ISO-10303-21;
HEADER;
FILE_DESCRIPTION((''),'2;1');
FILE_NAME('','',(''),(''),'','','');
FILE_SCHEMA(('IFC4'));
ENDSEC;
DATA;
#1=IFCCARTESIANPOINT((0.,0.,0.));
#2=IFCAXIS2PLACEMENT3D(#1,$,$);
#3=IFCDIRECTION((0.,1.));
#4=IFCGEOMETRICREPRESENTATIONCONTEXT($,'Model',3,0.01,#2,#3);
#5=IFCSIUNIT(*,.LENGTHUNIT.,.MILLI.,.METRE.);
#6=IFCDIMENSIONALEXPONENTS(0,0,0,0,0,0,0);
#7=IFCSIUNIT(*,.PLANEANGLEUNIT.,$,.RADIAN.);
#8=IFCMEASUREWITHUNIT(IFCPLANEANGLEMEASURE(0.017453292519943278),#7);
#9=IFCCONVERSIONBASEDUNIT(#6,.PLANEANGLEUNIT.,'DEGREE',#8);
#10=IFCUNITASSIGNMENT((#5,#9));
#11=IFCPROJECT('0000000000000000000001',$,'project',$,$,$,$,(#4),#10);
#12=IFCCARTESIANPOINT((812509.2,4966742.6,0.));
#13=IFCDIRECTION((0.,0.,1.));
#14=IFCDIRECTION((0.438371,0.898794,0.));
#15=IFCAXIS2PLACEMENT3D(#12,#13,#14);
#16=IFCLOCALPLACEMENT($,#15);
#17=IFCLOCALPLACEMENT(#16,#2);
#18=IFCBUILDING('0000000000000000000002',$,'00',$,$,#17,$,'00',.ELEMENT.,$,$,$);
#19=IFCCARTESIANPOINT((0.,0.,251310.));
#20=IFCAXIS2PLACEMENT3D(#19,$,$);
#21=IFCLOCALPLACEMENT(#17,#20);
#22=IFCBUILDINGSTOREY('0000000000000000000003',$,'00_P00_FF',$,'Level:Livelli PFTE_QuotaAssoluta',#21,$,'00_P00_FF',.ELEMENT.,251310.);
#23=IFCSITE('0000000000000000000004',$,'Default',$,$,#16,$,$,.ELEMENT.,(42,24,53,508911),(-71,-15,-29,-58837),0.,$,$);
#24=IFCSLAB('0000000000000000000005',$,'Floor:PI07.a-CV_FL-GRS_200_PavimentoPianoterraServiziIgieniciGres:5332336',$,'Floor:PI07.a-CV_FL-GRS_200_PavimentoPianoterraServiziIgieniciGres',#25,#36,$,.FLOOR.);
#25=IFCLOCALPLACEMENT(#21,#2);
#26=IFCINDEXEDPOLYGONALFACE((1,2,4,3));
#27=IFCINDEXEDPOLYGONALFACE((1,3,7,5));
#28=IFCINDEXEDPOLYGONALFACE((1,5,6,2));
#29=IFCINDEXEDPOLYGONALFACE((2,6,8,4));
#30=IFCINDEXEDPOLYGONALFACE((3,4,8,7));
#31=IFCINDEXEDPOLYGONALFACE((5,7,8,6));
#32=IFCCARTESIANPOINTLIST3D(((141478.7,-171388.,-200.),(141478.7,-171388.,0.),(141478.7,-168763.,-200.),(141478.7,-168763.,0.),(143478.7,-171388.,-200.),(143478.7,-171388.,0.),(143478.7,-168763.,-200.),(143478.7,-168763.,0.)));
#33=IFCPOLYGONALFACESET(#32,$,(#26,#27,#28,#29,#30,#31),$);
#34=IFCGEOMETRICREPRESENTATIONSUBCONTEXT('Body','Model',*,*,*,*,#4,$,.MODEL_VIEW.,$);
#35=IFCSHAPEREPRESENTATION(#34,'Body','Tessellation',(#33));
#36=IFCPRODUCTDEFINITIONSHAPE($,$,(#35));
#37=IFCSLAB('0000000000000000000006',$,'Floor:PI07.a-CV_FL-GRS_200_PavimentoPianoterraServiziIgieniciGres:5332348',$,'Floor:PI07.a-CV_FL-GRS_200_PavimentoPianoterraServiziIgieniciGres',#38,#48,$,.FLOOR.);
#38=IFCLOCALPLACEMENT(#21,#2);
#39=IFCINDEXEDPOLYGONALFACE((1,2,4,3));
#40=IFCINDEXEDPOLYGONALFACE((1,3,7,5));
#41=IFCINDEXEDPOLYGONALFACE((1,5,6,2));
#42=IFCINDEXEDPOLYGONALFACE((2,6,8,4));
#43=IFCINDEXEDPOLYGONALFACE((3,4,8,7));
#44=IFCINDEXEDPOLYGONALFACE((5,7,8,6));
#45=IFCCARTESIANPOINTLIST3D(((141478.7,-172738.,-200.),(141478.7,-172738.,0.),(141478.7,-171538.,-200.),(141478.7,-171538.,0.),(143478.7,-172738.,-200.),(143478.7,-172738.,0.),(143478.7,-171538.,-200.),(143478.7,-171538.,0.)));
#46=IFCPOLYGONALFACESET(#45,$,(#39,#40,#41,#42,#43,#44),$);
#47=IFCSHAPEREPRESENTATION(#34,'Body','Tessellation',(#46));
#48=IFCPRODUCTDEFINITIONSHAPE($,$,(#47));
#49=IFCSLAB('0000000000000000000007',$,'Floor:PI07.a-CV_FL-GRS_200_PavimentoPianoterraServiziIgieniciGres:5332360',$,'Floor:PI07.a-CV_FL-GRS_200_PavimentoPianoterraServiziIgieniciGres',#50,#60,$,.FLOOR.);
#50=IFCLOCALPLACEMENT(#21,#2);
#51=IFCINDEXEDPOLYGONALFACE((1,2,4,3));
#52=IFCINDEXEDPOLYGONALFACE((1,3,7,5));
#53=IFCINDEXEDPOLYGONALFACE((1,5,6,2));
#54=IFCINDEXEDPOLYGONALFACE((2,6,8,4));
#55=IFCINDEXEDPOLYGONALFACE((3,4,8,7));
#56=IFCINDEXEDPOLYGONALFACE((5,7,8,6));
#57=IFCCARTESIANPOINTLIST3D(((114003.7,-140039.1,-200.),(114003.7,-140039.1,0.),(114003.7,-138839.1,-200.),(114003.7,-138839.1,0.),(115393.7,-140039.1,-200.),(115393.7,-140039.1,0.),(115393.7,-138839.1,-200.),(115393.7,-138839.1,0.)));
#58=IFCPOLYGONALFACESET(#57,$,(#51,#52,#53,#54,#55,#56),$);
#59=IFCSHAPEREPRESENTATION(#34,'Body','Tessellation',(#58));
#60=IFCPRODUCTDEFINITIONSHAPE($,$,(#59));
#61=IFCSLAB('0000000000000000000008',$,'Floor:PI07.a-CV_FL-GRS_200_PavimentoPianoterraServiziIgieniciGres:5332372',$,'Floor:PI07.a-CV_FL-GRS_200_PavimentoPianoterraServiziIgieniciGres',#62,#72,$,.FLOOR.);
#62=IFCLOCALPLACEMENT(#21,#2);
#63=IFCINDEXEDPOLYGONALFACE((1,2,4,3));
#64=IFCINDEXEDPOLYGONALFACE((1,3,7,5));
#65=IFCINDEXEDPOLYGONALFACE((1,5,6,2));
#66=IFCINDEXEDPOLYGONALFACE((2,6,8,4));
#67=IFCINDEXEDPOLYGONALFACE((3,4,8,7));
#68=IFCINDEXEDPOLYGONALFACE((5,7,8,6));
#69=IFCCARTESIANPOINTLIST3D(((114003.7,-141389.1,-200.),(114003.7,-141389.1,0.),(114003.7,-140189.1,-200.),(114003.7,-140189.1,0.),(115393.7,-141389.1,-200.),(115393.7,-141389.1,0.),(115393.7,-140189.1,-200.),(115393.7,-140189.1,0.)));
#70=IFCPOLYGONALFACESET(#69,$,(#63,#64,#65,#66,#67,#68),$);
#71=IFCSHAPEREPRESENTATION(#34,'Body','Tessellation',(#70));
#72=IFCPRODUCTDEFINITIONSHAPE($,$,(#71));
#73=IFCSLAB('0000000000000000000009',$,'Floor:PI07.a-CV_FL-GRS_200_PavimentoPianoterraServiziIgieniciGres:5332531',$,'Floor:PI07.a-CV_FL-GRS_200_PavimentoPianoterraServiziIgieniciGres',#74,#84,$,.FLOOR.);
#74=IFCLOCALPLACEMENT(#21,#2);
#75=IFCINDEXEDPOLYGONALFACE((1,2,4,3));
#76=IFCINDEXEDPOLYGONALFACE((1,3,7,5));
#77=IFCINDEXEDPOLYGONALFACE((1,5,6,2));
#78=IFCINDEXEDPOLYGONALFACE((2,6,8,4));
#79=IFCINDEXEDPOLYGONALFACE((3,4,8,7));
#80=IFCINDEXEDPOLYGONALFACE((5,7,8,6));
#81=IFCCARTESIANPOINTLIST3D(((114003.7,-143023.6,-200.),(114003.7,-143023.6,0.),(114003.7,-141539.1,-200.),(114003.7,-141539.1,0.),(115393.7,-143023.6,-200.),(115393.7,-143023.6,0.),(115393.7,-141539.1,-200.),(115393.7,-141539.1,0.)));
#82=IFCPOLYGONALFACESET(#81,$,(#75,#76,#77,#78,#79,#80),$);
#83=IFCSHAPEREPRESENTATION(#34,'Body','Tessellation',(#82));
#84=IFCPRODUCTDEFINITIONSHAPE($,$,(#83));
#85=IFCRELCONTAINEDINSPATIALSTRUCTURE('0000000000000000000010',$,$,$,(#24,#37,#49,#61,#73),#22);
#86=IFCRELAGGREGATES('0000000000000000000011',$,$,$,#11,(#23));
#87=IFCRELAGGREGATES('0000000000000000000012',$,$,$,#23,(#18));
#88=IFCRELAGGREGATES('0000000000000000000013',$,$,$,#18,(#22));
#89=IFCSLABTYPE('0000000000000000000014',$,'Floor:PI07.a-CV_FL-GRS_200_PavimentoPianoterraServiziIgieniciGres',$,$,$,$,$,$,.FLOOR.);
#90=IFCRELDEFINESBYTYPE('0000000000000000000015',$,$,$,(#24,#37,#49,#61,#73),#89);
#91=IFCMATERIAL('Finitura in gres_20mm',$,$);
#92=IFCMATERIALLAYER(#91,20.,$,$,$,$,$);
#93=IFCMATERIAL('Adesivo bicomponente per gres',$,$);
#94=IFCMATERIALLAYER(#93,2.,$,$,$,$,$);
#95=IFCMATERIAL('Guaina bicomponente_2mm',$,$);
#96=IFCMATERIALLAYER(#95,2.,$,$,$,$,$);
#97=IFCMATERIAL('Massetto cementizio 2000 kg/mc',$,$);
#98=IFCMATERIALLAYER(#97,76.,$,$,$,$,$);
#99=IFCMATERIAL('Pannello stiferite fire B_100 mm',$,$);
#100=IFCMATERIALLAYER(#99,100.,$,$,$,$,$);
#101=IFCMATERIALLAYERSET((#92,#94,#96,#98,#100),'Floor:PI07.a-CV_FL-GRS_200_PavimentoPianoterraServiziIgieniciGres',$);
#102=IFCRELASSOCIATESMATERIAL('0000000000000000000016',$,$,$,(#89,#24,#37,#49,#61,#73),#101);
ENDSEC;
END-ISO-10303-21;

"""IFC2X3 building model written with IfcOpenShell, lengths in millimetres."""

from ifc_helpers import new_model, entity, si_unit, converted_unit, direction, frame, frame_2d, origin, origin_2d_with_axis, place, context, subcontext, project, spatial, rectangle, extrude, material, layer, layer_set, layer_usage, type_object, element, save


model = new_model("IFC2X3")

# Units and contexts
model_context = context("Model", 3, precision=0.01, world=origin(), true_north=direction((0.0, 1.0)))
body_context = subcontext(model_context, "Body", "Model", "MODEL_VIEW")
ifc_project = project(units=[si_unit("LENGTHUNIT", "METRE", prefix="MILLI"), converted_unit("PLANEANGLEUNIT", "DEGREE", entity("IfcPlaneAngleMeasure", 0.017453292519943278), si_unit("PLANEANGLEUNIT", "RADIAN"), dimensions=[0, 0, 0, 0, 0, 0, 0])], contexts=[model_context])

# Site, building, storey
site_placement = place(None, frame((812509.2, 4966742.6, 0.0), z_axis=(0.0, 0.0, 1.0), x_axis=(0.438371, 0.898794, 0.0)))
site = spatial("IfcSite", under=ifc_project, at=site_placement, Name="Default", CompositionType="ELEMENT", RefLatitude=(42, 24, 53, 508911), RefLongitude=(-71, -15, -29, -58837), RefElevation=0.0)
building_placement = place(site_placement, origin())
building = spatial("IfcBuilding", under=site, at=building_placement, Name="00", LongName="00", CompositionType="ELEMENT")
storey_placement = place(building_placement, frame((0.0, 0.0, 251310.0)))
storey = spatial("IfcBuildingStorey", under=building, at=storey_placement, Name="00_P00_FF", ObjectType="Level:Livelli PFTE_QuotaAssoluta", LongName="00_P00_FF", CompositionType="ELEMENT", Elevation=251310.0)

# Slabs
ifc_material_1 = material(Name="Finitura in gres_20mm")
ifc_layer_1 = layer(ifc_material_1, 20.0)
ifc_material_2 = material(Name="Adesivo bicomponente per gres")
ifc_layer_2 = layer(ifc_material_2, 2.0)
ifc_material_3 = material(Name="Guaina bicomponente_2mm")
ifc_layer_3 = layer(ifc_material_3, 2.0)
ifc_material_4 = material(Name="Massetto cementizio 2000 kg/mc")
ifc_layer_4 = layer(ifc_material_4, 76.0)
ifc_material_5 = material(Name="Pannello stiferite fire B_100 mm")
ifc_layer_5 = layer(ifc_material_5, 100.0)
ifc_layer_set = layer_set([ifc_layer_1, ifc_layer_2, ifc_layer_3, ifc_layer_4, ifc_layer_5], Name="Floor:PI07.a-CV_FL-GRS_200_PavimentoPianoterraServiziIgieniciGres")
slab_type = type_object("IfcSlabType", Name="Floor:PI07.a-CV_FL-GRS_200_PavimentoPianoterraServiziIgieniciGres", PredefinedType="FLOOR", material=ifc_layer_set)
ifc_layer_usage_1 = layer_usage(ifc_layer_set, "AXIS3", "POSITIVE", 0.0)
slab_1_placement = place(storey_placement, origin())
element("IfcSlab", 1, at=slab_1_placement, inside=storey, type_object=slab_type, material=ifc_layer_usage_1, Name="Floor:PI07.a-CV_FL-GRS_200_PavimentoPianoterraServiziIgieniciGres:5332336", ObjectType="Floor:PI07.a-CV_FL-GRS_200_PavimentoPianoterraServiziIgieniciGres", PredefinedType="FLOOR", context=body_context, shape_type="SweptSolid", body=[
    extrude(rectangle(XDim=2625.0, YDim=2000.0, at=origin_2d_with_axis()), frame((142478.7, -170075.5, 0.0), z_axis=(0.0, 0.0, -1.0), x_axis=(0.0, 1.0, 0.0)), (0.0, 0.0, 1.0), 200.0),
])
ifc_layer_usage_2 = layer_usage(ifc_layer_set, "AXIS3", "POSITIVE", 0.0)
slab_2_placement = place(storey_placement, origin())
element("IfcSlab", 2, at=slab_2_placement, inside=storey, type_object=slab_type, material=ifc_layer_usage_2, Name="Floor:PI07.a-CV_FL-GRS_200_PavimentoPianoterraServiziIgieniciGres:5332348", ObjectType="Floor:PI07.a-CV_FL-GRS_200_PavimentoPianoterraServiziIgieniciGres", PredefinedType="FLOOR", context=body_context, shape_type="SweptSolid", body=[
    extrude(rectangle(XDim=1200.0, YDim=2000.0, at=origin_2d_with_axis()), frame((142478.7, -172138.0, 0.0), z_axis=(0.0, 0.0, -1.0), x_axis=(0.0, 1.0, 0.0)), (0.0, 0.0, 1.0), 200.0),
])
ifc_layer_usage_3 = layer_usage(ifc_layer_set, "AXIS3", "POSITIVE", 0.0)
slab_3_placement = place(storey_placement, origin())
element("IfcSlab", 3, at=slab_3_placement, inside=storey, type_object=slab_type, material=ifc_layer_usage_3, Name="Floor:PI07.a-CV_FL-GRS_200_PavimentoPianoterraServiziIgieniciGres:5332360", ObjectType="Floor:PI07.a-CV_FL-GRS_200_PavimentoPianoterraServiziIgieniciGres", PredefinedType="FLOOR", context=body_context, shape_type="SweptSolid", body=[
    extrude(rectangle(XDim=1200.0, YDim=1390.0, at=frame_2d((0.0, 0.0), x_axis=(1.0, 0.0))), frame((114698.7, -139439.1, 0.0), z_axis=(0.0, 0.0, -1.0), x_axis=(0.0, 1.0, 0.0)), (0.0, 0.0, 1.0), 200.0),
])
ifc_layer_usage_4 = layer_usage(ifc_layer_set, "AXIS3", "POSITIVE", 0.0)
slab_4_placement = place(storey_placement, origin())
element("IfcSlab", 4, at=slab_4_placement, inside=storey, type_object=slab_type, material=ifc_layer_usage_4, Name="Floor:PI07.a-CV_FL-GRS_200_PavimentoPianoterraServiziIgieniciGres:5332372", ObjectType="Floor:PI07.a-CV_FL-GRS_200_PavimentoPianoterraServiziIgieniciGres", PredefinedType="FLOOR", context=body_context, shape_type="SweptSolid", body=[
    extrude(rectangle(XDim=1200.0, YDim=1390.0, at=frame_2d((0.0, 0.0), x_axis=(1.0, 0.0))), frame((114698.7, -140789.1, 0.0), z_axis=(0.0, 0.0, -1.0), x_axis=(0.0, 1.0, 0.0)), (0.0, 0.0, 1.0), 200.0),
])

# Slab
ifc_layer_usage_5 = layer_usage(ifc_layer_set, "AXIS3", "POSITIVE", 0.0)
slab_5_placement = place(storey_placement, origin())
element("IfcSlab", 5, at=slab_5_placement, inside=storey, type_object=slab_type, material=ifc_layer_usage_5, Name="Floor:PI07.a-CV_FL-GRS_200_PavimentoPianoterraServiziIgieniciGres:5332531", ObjectType="Floor:PI07.a-CV_FL-GRS_200_PavimentoPianoterraServiziIgieniciGres", PredefinedType="FLOOR", context=body_context, shape_type="SweptSolid", body=[
    extrude(rectangle(XDim=1484.5, YDim=1390.0, at=frame_2d((0.0, 0.0), x_axis=(1.0, 0.0))), frame((114698.7, -142281.4, 0.0), z_axis=(0.0, 0.0, -1.0), x_axis=(0.0, 1.0, 0.0)), (0.0, 0.0, 1.0), 200.0),
])

save(model, "model.ifc")
